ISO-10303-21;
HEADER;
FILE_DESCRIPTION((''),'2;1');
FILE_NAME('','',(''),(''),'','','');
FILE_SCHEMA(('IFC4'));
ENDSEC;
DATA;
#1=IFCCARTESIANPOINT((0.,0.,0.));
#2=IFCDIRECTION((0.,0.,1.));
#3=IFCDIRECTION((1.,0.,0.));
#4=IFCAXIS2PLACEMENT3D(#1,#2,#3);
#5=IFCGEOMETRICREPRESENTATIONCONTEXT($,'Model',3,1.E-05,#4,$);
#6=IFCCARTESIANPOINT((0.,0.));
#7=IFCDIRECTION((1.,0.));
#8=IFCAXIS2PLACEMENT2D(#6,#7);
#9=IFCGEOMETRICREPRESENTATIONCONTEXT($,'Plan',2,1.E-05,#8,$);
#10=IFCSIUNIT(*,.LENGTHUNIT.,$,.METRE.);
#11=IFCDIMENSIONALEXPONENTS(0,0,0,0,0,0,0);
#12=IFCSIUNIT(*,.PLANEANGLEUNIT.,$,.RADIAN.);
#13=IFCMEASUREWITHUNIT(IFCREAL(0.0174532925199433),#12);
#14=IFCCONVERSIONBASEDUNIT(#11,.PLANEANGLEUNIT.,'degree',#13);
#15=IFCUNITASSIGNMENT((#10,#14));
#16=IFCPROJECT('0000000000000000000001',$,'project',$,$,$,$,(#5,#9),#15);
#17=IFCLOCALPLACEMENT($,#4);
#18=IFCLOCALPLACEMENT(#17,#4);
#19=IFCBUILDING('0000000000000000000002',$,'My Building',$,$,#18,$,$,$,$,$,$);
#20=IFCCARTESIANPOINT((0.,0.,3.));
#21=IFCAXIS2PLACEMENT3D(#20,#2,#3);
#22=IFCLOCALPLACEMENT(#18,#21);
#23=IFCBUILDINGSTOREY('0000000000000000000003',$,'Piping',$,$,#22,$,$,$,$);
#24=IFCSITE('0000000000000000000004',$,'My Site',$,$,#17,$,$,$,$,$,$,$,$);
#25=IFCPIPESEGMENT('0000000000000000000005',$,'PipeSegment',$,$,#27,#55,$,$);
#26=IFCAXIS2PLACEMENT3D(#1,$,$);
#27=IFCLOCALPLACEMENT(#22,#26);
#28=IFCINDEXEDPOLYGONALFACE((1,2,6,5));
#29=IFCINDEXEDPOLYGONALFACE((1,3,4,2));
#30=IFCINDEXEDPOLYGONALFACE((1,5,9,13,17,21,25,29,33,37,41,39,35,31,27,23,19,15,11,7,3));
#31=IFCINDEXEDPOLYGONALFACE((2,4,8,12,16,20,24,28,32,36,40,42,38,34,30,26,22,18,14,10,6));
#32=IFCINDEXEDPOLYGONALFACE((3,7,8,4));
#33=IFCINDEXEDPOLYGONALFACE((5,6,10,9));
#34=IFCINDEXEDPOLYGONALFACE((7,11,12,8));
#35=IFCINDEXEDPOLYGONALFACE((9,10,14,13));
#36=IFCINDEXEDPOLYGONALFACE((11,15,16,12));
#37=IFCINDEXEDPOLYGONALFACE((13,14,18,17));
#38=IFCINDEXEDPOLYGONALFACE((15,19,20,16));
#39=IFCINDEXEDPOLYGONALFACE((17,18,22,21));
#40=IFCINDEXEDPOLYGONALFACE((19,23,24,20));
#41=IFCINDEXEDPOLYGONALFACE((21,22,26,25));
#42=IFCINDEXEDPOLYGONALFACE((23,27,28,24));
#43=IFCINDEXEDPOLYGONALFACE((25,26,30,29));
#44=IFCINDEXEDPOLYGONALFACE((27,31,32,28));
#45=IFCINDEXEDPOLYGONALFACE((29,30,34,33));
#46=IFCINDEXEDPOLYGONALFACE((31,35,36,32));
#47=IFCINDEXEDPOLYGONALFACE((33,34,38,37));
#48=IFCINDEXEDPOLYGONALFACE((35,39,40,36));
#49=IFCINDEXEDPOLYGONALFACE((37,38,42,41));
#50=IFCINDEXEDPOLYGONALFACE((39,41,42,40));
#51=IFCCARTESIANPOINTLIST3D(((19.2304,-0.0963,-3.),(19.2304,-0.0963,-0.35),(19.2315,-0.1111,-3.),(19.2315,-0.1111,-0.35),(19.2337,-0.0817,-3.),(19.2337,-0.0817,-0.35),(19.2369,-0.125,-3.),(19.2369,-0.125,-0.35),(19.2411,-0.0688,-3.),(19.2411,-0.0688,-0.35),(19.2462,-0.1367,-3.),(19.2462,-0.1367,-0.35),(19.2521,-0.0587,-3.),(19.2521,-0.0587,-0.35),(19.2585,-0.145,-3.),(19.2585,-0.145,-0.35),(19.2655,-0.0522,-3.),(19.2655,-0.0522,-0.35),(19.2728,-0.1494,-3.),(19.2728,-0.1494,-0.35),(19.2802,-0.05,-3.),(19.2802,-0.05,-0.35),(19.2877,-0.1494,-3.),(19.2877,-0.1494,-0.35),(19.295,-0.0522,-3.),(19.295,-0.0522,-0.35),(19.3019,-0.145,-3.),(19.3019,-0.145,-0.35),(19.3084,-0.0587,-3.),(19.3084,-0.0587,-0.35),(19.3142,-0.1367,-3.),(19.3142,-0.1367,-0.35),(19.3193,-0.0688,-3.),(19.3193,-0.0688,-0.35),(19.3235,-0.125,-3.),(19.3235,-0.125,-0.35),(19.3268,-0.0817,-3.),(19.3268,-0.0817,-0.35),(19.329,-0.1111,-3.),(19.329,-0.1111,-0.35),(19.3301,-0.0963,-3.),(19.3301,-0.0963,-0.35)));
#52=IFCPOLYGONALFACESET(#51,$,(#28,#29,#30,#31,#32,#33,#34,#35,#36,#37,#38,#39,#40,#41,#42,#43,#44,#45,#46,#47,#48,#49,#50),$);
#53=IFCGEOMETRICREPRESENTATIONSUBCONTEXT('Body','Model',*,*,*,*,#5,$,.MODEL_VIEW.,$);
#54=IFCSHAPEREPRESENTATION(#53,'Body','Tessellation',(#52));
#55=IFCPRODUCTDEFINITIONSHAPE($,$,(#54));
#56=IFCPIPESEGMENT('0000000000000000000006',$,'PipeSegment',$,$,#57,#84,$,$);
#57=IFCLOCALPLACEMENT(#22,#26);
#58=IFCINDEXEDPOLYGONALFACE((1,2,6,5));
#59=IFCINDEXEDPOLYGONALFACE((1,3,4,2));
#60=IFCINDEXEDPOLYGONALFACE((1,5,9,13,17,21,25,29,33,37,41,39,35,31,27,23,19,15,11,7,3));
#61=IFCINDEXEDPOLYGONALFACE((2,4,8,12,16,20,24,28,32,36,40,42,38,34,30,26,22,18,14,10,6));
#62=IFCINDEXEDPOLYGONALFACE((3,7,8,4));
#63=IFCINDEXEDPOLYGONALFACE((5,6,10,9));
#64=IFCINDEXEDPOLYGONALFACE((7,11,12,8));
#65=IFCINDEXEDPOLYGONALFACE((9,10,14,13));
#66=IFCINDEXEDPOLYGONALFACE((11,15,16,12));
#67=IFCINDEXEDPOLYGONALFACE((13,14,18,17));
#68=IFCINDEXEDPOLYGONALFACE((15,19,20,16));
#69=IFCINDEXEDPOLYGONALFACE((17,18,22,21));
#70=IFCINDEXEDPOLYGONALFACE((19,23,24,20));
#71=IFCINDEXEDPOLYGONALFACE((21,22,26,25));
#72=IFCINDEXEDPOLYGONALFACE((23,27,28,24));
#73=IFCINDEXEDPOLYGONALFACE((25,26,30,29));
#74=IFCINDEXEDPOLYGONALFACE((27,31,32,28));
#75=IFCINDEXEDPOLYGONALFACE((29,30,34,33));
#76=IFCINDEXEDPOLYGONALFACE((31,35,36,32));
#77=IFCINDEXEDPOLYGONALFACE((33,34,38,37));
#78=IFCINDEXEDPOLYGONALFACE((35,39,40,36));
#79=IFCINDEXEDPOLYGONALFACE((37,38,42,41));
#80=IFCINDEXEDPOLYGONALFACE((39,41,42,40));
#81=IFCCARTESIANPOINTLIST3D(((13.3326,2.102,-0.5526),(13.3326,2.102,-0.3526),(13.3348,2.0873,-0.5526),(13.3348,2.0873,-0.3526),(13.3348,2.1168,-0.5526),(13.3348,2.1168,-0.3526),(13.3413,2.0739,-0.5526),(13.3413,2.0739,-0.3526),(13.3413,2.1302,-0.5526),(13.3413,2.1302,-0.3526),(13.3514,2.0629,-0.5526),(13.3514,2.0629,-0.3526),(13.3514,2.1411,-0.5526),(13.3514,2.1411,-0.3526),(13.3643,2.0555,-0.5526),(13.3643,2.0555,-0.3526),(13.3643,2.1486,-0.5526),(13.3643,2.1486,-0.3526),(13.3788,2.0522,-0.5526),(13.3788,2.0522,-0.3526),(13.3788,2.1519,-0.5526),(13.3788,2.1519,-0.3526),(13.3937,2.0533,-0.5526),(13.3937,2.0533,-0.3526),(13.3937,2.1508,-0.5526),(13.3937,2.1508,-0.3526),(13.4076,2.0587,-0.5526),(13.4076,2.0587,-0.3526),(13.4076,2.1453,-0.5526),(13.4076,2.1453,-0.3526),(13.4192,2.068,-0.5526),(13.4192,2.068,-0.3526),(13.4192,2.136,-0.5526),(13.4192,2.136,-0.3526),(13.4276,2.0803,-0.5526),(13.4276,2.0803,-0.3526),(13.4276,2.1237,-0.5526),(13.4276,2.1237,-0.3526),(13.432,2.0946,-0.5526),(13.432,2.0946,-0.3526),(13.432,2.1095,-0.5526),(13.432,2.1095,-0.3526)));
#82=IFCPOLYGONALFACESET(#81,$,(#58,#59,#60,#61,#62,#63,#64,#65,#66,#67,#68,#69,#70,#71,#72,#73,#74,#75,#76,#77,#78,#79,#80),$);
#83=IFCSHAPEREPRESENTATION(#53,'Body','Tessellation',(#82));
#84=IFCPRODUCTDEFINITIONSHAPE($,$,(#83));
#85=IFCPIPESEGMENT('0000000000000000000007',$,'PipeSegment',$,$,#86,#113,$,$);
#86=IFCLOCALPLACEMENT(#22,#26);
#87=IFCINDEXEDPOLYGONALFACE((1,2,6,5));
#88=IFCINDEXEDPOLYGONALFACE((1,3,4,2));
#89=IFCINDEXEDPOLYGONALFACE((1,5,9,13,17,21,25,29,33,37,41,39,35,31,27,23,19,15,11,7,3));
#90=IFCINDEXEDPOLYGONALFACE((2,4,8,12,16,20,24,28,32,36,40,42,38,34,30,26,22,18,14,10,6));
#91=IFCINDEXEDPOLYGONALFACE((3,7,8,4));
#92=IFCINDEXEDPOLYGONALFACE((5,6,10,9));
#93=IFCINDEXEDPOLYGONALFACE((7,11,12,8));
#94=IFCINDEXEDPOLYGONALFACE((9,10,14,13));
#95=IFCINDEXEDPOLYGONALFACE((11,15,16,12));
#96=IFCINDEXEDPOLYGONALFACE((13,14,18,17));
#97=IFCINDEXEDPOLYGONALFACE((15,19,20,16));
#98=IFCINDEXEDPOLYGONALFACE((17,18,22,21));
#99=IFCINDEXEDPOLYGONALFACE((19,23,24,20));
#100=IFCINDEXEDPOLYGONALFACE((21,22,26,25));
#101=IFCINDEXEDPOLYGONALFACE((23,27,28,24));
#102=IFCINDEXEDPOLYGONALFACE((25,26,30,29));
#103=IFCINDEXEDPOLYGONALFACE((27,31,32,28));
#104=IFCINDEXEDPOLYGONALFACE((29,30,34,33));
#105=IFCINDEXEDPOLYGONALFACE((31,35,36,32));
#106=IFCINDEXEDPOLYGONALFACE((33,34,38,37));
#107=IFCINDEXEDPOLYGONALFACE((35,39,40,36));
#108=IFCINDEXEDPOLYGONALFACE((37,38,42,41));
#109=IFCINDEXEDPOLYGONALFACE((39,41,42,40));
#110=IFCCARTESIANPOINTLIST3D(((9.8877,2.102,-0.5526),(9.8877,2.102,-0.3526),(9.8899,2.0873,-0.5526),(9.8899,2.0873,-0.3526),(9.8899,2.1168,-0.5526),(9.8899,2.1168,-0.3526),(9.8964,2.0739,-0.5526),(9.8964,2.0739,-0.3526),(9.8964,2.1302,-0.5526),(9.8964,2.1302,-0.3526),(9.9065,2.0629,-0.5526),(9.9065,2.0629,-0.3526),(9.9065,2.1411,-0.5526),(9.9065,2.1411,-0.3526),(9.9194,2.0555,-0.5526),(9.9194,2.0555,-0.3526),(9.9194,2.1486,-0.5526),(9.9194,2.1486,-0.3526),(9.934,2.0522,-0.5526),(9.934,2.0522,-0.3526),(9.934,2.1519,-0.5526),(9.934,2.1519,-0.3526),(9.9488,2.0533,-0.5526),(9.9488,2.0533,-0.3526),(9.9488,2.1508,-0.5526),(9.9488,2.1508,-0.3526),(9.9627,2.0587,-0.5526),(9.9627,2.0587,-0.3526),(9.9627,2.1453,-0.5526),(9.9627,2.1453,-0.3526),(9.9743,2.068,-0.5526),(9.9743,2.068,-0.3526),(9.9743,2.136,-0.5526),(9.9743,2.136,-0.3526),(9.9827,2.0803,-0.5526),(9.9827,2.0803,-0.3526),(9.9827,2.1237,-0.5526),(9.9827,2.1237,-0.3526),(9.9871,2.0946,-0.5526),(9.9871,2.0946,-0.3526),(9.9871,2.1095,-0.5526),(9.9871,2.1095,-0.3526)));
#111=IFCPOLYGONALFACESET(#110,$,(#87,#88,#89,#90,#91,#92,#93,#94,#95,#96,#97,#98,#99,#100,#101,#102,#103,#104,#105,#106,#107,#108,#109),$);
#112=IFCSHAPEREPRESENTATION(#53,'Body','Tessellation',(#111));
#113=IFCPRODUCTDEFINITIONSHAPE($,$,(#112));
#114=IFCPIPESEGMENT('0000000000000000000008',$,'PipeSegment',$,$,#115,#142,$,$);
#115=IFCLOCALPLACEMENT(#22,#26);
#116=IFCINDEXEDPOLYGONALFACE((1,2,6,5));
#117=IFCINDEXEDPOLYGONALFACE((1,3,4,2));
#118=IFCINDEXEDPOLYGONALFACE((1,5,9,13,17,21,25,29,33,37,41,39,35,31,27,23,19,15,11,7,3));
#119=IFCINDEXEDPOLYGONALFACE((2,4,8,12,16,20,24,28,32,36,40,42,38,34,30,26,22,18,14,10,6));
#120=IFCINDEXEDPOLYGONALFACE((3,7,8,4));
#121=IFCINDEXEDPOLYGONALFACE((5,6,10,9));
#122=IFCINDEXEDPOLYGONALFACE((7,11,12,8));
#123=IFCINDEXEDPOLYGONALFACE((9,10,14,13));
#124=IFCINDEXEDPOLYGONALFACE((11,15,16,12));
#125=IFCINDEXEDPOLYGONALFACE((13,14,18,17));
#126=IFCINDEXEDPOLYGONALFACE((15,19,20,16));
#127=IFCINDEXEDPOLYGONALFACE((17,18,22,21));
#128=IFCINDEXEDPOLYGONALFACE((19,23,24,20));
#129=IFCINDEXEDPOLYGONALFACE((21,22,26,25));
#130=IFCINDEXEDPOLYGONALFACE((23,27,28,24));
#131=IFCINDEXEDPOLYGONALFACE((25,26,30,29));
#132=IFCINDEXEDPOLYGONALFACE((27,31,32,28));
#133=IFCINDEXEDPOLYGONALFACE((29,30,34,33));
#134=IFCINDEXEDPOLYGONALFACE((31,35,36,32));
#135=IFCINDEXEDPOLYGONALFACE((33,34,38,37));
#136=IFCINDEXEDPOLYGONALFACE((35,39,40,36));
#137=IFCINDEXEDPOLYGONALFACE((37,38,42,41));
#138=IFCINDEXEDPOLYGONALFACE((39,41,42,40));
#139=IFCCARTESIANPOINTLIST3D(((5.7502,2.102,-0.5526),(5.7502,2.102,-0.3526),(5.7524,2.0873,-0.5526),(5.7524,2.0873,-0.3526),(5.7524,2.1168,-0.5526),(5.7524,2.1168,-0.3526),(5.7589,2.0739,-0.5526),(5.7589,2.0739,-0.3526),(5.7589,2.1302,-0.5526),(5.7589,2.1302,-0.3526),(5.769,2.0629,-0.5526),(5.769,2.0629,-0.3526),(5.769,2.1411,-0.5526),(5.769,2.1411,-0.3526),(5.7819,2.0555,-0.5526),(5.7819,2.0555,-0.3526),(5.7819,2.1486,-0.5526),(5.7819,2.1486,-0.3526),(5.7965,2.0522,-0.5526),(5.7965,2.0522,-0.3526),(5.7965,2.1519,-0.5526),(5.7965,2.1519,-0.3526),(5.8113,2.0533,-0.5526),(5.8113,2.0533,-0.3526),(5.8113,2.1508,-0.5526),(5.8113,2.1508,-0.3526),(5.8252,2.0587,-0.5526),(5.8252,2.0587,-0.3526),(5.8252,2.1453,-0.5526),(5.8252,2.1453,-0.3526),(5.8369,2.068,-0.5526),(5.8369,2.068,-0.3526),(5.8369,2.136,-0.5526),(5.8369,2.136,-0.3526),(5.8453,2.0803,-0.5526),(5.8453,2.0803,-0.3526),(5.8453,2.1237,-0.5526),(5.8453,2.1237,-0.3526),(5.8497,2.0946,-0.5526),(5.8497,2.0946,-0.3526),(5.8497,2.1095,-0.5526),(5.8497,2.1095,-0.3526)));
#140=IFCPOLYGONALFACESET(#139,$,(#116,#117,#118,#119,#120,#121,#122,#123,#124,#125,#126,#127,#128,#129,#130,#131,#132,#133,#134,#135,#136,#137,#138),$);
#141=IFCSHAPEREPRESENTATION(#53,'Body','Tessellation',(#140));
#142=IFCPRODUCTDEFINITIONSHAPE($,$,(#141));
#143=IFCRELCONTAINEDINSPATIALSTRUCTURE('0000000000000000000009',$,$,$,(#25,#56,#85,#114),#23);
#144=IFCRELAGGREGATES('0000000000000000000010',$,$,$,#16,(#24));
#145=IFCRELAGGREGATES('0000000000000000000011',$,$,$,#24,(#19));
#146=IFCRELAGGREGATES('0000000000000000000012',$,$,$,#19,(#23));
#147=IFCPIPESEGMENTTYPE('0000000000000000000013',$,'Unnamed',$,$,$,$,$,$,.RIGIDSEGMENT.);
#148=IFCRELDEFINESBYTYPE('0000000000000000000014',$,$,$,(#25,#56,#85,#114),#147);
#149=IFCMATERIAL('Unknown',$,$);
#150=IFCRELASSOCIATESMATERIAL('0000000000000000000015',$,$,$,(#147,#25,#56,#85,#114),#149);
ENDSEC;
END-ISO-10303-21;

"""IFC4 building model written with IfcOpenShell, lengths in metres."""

from ifc_helpers import new_model, entity, si_unit, converted_unit, frame, origin_with_axes, origin_2d_with_axis, place, context, subcontext, project, spatial, circle, extrude, material, material_profile, profile_set, profile_usage, type_object, element, save


model = new_model("IFC4")

# Units and contexts
model_context = context("Model", 3, precision=1e-05, world=origin_with_axes())
plan_context = context("Plan", 2, precision=1e-05, world=origin_2d_with_axis())
body_context = subcontext(model_context, "Body", "Model", "MODEL_VIEW")
ifc_project = project(units=[si_unit("LENGTHUNIT", "METRE"), converted_unit("PLANEANGLEUNIT", "degree", entity("IfcReal", 0.0174532925199433), si_unit("PLANEANGLEUNIT", "RADIAN"), dimensions=[0, 0, 0, 0, 0, 0, 0])], contexts=[model_context, plan_context])

# Site, building, storey
site_placement = place(None, origin_with_axes())
site = spatial("IfcSite", under=ifc_project, at=site_placement, Name="My Site")
building_placement = place(site_placement, origin_with_axes())
building = spatial("IfcBuilding", under=site, at=building_placement, Name="My Building")
storey_placement = place(building_placement, frame((0.0, 0.0, 3.0), z_axis=(0.0, 0.0, 1.0), x_axis=(1.0, 0.0, 0.0)))
storey = spatial("IfcBuildingStorey", under=building, at=storey_placement, Name="Piping")

# Pipe segments
ifc_material = material(Name="Unknown")
ifc_material_profile = material_profile(ifc_material, circle(Radius=0.05))
ifc_profile_set = profile_set([ifc_material_profile])
pipe_segment_type = type_object("IfcPipeSegmentType", Name="Unnamed", PredefinedType="RIGIDSEGMENT", material=ifc_profile_set)
ifc_profile_usage_1 = profile_usage(ifc_profile_set, cardinal=5)
pipe_segment_1_placement = place(storey_placement, frame((19.2802, -0.1, -0.35), z_axis=(0.0, 0.0, -1.0), x_axis=(0.0, 1.0, 0.0)))
element("IfcPipeSegment", 1, at=pipe_segment_1_placement, inside=storey, type_object=pipe_segment_type, material=ifc_profile_usage_1, Name="PipeSegment", context=body_context, shape_type="SweptSolid", body=[
    extrude(circle(Radius=0.05), origin_with_axes(), (0.0, 0.0, 1.0), 2.65),
])
ifc_profile_usage_2 = profile_usage(ifc_profile_set, cardinal=5)
pipe_segment_2_placement = place(storey_placement, frame((13.3826, 2.102, -0.3526), z_axis=(0.0, 0.0, -1.0), x_axis=(-1.0, 0.0, 0.0)))
element("IfcPipeSegment", 2, at=pipe_segment_2_placement, inside=storey, type_object=pipe_segment_type, material=ifc_profile_usage_2, Name="PipeSegment", context=body_context, shape_type="SweptSolid", body=[
    extrude(circle(Radius=0.05), origin_with_axes(), (0.0, 0.0, 1.0), 0.2),
])
ifc_profile_usage_3 = profile_usage(ifc_profile_set, cardinal=5)
pipe_segment_3_placement = place(storey_placement, frame((9.9377, 2.102, -0.3526), z_axis=(0.0, 0.0, -1.0), x_axis=(-1.0, 0.0, 0.0)))
element("IfcPipeSegment", 3, at=pipe_segment_3_placement, inside=storey, type_object=pipe_segment_type, material=ifc_profile_usage_3, Name="PipeSegment", context=body_context, shape_type="SweptSolid", body=[
    extrude(circle(Radius=0.05), origin_with_axes(), (0.0, 0.0, 1.0), 0.2),
])
ifc_profile_usage_4 = profile_usage(ifc_profile_set, cardinal=5)
pipe_segment_4_placement = place(storey_placement, frame((5.8002, 2.102, -0.3526), z_axis=(0.0, 0.0, -1.0), x_axis=(-1.0, 0.0, 0.0)))
element("IfcPipeSegment", 4, at=pipe_segment_4_placement, inside=storey, type_object=pipe_segment_type, material=ifc_profile_usage_4, Name="PipeSegment", context=body_context, shape_type="SweptSolid", body=[
    extrude(circle(Radius=0.05), origin_with_axes(), (0.0, 0.0, 1.0), 0.2),
])

save(model, "model.ifc")
